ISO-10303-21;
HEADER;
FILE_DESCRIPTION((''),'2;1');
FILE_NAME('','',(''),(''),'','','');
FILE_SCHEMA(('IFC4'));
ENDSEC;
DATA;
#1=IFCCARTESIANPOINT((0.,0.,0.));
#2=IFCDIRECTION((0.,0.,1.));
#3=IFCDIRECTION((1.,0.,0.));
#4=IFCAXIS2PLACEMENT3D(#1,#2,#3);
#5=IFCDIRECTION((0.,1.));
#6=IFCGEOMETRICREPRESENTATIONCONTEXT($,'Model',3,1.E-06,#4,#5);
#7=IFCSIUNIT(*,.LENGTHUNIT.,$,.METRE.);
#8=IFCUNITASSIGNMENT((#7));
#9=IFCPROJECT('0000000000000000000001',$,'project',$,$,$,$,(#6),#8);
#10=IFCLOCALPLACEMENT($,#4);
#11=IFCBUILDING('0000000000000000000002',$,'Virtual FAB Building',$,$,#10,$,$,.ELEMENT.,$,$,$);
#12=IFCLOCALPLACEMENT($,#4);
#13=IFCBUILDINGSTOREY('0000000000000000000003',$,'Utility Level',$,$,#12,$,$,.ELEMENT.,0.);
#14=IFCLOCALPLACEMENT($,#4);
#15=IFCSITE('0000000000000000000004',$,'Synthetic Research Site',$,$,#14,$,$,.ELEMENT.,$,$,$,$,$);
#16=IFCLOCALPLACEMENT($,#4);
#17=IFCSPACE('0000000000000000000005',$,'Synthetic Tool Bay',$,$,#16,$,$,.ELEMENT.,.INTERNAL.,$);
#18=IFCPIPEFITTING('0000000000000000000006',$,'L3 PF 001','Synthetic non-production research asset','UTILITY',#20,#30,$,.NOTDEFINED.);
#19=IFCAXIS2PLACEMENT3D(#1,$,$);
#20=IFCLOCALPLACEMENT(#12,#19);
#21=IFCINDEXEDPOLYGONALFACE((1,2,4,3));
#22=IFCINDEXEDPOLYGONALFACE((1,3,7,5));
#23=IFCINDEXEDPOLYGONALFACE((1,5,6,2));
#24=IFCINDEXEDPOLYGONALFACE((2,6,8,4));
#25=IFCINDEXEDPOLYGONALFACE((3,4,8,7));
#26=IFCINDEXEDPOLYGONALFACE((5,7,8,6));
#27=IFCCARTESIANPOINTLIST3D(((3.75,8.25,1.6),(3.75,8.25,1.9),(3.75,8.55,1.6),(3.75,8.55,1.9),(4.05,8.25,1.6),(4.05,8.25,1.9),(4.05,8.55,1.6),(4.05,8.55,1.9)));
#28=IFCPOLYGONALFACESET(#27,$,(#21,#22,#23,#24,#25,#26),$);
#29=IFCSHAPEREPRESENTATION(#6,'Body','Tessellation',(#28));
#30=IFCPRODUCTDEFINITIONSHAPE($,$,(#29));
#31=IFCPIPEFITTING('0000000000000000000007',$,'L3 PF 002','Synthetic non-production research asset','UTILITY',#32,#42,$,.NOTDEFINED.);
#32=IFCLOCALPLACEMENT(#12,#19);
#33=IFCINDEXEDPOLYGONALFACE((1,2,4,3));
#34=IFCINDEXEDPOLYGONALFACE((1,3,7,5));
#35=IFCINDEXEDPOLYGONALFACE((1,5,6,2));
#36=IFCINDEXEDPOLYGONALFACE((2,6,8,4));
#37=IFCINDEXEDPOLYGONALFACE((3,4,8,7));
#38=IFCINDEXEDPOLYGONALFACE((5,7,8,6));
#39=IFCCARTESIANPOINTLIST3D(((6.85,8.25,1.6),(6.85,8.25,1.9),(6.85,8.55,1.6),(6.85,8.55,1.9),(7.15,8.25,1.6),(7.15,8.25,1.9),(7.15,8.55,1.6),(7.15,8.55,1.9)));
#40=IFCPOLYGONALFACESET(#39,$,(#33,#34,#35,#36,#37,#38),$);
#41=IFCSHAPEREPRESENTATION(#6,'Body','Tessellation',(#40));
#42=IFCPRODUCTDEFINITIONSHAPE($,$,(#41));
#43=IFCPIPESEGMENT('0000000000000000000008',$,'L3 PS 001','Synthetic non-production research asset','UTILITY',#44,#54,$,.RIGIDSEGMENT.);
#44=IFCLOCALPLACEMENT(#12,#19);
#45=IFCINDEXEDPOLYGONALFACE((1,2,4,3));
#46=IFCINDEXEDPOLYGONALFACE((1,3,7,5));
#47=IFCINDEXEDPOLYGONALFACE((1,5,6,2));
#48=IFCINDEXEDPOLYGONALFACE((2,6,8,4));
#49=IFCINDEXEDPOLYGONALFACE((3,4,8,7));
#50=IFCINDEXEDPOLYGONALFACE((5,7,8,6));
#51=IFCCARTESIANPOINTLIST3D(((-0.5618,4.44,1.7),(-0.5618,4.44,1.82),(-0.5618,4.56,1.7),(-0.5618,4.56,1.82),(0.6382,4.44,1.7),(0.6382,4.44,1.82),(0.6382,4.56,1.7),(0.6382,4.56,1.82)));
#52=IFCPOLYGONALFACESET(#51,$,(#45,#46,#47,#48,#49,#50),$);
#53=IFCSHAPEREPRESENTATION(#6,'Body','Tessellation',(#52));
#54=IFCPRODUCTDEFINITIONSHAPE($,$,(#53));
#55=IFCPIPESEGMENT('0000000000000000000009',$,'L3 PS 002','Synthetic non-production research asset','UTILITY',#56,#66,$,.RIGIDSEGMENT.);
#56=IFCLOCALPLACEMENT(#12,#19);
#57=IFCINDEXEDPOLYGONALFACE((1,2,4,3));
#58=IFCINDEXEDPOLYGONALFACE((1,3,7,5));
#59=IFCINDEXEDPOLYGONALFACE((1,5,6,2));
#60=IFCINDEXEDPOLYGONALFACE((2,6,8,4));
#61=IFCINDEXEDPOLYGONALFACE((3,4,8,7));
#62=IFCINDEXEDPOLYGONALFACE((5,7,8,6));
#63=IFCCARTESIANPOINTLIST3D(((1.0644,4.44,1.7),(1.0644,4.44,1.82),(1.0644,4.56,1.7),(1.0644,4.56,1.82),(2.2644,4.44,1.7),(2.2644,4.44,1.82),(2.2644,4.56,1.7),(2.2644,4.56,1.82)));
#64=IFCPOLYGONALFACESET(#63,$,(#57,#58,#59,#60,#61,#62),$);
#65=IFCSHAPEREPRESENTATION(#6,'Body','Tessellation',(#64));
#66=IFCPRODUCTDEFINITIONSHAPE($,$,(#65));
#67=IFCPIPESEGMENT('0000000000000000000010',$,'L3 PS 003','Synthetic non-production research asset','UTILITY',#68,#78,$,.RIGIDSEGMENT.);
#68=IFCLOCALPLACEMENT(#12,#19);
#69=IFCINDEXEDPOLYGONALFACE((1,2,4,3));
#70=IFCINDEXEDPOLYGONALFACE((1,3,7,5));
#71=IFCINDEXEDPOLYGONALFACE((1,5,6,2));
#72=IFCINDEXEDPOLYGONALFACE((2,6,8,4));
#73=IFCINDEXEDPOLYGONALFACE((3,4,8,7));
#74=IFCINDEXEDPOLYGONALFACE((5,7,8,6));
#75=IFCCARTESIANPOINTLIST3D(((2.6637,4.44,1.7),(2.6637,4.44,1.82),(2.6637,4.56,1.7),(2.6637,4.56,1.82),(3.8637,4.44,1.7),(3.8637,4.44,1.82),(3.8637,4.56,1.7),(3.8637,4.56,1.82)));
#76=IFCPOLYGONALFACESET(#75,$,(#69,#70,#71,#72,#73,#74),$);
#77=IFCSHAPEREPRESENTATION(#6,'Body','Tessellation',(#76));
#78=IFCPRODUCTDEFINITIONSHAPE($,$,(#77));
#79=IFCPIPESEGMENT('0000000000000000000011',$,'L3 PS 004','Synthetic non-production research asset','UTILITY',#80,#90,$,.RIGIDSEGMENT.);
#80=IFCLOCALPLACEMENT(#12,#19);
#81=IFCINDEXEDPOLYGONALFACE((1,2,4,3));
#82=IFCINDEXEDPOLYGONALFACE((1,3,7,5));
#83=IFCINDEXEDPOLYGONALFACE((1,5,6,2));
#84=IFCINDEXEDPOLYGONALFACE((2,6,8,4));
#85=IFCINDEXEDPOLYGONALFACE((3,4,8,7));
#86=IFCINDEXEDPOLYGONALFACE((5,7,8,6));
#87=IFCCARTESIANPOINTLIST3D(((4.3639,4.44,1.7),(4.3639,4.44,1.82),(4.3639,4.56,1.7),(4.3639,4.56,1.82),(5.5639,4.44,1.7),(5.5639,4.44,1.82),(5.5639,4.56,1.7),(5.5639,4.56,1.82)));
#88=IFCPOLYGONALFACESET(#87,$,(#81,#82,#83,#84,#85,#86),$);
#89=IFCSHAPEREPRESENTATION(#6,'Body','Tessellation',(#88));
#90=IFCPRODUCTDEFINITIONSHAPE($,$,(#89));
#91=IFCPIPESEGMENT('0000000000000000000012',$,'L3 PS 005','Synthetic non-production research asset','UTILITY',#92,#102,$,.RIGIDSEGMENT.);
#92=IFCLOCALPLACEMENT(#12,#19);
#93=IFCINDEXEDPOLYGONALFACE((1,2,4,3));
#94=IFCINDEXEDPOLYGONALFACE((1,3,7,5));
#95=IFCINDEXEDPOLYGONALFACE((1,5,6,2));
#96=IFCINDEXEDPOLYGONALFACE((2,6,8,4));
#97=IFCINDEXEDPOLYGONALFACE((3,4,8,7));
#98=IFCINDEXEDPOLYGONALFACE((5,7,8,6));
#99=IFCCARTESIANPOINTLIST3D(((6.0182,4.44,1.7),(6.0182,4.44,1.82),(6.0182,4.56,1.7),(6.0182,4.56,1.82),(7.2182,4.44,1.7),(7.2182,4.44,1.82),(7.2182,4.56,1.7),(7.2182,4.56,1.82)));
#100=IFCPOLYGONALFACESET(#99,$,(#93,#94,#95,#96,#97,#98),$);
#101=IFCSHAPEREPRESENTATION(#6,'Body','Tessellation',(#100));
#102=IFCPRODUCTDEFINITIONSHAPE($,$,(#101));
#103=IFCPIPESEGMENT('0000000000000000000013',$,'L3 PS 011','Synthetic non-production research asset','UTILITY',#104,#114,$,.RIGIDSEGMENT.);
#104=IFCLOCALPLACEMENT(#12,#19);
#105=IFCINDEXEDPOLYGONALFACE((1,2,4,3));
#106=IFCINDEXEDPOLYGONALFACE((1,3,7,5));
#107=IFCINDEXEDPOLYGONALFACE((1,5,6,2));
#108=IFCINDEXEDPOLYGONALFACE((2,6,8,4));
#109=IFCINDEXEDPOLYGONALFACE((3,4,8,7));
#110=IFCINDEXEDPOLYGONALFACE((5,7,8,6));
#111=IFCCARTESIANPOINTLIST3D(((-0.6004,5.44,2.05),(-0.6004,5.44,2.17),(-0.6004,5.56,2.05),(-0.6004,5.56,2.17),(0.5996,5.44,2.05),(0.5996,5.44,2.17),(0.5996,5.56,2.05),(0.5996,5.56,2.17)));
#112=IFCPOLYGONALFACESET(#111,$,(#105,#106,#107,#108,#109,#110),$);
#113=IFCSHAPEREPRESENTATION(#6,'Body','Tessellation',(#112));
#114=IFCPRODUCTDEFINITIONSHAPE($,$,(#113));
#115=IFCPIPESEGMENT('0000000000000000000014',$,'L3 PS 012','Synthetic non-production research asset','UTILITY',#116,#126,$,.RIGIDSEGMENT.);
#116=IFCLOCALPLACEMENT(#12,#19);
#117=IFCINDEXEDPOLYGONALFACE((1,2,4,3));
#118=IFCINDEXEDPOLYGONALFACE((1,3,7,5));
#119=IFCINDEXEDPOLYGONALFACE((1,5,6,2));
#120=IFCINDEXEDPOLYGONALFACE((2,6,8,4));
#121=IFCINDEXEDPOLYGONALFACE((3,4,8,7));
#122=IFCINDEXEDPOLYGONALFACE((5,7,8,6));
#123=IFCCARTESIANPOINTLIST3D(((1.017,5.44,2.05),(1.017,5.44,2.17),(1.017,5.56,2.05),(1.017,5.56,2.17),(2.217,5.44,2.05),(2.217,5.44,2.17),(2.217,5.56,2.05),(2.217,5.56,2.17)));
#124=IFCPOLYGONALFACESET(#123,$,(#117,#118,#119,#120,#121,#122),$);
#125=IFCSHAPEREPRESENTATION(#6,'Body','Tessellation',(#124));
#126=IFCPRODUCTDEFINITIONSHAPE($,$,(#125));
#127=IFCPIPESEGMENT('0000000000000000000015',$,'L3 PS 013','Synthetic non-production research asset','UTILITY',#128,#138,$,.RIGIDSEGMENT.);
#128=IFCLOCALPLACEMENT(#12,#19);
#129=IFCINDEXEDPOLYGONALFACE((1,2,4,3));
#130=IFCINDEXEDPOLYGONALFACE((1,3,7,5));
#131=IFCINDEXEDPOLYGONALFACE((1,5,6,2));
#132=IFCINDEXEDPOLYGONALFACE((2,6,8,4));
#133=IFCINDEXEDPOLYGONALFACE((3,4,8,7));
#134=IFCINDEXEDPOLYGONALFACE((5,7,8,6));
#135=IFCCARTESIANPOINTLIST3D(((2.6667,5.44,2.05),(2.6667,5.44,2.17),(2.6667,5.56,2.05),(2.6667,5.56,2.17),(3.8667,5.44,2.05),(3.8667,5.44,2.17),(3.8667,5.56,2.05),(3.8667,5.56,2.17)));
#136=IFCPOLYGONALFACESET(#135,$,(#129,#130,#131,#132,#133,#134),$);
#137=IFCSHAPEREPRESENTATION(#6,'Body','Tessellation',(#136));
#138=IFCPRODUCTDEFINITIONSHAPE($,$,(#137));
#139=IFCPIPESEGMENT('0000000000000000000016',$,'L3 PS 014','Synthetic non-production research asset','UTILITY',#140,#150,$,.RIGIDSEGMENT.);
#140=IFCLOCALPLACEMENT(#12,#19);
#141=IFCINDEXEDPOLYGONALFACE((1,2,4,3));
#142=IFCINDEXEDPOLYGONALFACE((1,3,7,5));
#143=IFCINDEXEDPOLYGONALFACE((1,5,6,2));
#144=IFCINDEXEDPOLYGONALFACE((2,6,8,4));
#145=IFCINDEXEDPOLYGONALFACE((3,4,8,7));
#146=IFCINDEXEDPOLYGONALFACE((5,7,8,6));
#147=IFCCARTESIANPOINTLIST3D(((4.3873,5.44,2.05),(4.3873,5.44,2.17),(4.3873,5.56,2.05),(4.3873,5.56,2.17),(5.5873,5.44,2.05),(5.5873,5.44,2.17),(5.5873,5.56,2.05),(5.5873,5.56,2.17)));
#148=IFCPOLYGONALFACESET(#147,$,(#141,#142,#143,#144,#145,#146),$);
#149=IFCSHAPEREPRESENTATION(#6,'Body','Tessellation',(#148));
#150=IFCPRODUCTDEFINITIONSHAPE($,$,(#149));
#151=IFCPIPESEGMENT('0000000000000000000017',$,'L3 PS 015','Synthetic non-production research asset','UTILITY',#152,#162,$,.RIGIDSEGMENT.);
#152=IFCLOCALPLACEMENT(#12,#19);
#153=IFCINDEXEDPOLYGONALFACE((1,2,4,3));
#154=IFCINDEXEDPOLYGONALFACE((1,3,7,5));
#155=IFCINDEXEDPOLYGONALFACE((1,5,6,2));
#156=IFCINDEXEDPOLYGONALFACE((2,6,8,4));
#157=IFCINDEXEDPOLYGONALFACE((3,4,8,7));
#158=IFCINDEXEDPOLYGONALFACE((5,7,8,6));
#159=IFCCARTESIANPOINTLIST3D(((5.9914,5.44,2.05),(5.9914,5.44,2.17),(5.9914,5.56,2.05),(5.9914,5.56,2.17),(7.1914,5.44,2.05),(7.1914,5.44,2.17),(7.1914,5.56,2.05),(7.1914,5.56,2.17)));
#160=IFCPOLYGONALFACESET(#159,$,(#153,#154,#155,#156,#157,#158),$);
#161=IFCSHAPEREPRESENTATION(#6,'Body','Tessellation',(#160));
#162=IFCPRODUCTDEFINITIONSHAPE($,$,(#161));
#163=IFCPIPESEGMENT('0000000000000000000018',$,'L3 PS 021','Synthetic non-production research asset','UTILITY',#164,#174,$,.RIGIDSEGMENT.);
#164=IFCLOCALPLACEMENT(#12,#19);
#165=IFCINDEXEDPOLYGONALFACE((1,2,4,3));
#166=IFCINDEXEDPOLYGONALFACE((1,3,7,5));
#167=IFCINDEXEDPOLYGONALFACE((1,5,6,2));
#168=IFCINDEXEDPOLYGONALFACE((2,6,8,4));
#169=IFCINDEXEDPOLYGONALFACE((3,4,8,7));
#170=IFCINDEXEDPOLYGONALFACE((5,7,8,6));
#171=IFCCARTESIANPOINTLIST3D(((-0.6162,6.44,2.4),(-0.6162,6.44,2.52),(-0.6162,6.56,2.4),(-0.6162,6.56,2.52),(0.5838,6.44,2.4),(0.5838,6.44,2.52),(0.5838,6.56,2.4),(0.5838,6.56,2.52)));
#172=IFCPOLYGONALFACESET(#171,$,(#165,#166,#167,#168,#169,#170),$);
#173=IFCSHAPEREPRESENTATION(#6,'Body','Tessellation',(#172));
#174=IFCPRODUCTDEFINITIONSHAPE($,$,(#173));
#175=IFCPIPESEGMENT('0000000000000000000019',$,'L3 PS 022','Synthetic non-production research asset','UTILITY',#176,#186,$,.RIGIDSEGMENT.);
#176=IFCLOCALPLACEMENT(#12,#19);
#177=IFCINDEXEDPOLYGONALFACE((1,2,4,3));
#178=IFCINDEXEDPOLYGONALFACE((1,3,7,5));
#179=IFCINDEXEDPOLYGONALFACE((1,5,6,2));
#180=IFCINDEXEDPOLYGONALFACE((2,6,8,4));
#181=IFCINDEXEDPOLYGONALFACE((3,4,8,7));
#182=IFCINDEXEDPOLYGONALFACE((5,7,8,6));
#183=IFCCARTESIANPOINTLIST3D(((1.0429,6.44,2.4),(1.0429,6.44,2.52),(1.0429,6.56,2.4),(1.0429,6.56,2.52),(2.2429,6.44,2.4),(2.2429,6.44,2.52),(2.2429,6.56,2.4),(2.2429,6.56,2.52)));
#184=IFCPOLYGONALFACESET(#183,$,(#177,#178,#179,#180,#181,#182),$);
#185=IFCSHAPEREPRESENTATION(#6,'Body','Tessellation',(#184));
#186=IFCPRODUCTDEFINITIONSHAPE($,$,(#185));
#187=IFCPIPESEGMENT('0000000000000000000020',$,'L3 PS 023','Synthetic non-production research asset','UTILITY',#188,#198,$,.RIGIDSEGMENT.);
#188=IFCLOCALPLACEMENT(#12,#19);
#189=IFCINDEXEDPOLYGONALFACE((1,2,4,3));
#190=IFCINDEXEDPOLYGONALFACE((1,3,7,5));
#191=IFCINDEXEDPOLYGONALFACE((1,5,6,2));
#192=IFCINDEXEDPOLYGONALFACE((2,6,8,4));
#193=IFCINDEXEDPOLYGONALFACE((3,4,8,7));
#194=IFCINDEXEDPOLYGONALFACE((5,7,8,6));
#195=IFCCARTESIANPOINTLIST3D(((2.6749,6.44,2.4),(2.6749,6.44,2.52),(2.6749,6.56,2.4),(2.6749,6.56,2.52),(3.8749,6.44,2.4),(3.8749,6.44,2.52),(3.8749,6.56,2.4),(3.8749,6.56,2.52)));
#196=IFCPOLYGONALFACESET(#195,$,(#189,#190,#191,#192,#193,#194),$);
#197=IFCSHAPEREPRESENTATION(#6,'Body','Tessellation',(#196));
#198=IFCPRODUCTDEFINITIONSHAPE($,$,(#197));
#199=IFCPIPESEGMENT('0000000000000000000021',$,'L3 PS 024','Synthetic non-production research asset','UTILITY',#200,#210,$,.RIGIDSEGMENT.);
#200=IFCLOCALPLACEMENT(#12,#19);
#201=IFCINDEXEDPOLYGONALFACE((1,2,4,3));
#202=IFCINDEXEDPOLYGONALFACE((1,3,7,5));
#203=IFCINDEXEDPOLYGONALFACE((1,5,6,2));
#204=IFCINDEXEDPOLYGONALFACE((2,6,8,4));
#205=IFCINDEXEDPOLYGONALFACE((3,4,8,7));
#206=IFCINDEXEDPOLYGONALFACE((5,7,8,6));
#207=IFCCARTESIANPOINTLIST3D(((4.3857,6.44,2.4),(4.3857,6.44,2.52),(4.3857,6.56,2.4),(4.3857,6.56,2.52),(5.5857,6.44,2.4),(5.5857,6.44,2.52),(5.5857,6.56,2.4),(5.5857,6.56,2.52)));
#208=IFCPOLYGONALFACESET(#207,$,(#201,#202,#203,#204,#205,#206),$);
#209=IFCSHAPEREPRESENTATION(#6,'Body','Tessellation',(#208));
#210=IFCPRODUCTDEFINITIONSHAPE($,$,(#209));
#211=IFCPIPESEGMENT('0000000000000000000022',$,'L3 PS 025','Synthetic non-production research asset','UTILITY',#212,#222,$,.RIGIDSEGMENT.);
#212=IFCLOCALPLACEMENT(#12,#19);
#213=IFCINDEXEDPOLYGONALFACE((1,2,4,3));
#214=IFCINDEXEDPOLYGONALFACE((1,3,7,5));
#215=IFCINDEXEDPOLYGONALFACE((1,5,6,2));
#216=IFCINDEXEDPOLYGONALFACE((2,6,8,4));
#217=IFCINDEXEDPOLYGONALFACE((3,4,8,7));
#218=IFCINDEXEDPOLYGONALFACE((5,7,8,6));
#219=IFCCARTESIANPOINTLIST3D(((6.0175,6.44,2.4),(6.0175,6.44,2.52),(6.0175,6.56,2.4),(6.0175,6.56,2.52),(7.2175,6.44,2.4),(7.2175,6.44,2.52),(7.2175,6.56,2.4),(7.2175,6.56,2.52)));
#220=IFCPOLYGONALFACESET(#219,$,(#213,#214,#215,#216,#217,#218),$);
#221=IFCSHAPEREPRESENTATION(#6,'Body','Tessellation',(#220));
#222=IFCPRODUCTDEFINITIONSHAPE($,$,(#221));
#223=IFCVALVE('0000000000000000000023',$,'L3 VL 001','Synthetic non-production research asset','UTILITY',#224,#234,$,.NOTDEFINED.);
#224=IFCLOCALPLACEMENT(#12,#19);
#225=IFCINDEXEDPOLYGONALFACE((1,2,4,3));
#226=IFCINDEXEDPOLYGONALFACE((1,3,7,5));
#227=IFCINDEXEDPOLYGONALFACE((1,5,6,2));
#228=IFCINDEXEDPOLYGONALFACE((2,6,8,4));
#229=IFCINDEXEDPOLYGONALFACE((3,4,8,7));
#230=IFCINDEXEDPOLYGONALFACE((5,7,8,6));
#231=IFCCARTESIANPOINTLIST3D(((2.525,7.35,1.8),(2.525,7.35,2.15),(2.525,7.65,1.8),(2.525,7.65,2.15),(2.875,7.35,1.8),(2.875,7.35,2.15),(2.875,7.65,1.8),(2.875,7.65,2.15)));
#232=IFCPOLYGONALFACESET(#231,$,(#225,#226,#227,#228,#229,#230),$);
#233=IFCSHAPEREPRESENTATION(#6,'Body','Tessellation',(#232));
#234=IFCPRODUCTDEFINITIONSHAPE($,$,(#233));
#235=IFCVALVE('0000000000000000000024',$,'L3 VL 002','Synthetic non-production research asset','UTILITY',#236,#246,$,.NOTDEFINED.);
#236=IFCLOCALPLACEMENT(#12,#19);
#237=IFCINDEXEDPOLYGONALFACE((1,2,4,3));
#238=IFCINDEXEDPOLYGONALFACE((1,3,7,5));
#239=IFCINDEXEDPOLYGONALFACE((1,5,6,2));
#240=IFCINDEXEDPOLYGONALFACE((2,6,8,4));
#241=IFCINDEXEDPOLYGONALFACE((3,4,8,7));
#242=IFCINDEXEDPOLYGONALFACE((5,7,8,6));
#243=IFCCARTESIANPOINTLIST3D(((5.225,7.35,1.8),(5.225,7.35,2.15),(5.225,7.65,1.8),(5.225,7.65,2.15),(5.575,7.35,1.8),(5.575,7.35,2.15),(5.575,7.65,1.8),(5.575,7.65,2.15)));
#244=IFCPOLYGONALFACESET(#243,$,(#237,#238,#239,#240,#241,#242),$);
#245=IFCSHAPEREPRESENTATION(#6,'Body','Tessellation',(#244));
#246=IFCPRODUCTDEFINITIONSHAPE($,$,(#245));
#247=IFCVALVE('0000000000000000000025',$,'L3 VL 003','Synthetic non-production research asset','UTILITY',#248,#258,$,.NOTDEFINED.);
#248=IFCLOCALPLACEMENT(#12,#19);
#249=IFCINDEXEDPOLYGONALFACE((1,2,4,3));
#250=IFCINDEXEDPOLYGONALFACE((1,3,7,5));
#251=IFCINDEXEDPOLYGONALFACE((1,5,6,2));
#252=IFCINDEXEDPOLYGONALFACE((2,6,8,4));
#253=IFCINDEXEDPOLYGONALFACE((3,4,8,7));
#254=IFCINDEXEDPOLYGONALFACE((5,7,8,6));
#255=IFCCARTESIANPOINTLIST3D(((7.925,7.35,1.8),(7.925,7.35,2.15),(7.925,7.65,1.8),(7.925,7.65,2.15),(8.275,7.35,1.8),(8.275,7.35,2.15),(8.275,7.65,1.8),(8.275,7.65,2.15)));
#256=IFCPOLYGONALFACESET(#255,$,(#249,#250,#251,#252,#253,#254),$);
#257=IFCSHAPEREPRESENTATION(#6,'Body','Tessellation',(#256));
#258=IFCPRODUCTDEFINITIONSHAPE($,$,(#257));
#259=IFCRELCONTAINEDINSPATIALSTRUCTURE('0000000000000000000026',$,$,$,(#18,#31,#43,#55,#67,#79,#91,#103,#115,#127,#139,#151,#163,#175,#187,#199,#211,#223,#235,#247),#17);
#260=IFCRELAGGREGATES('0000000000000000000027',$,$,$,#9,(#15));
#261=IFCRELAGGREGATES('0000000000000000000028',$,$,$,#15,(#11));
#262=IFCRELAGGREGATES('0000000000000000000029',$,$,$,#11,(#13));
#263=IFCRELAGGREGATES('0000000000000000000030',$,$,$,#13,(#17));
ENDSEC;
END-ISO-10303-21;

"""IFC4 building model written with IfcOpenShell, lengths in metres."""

from ifc_helpers import new_model, si_unit, direction, frame, origin_with_axes, origin_2d_with_axis, place, context, project, spatial, rectangle, extrude, element, save


model = new_model("IFC4")

# Units and contexts
model_context = context("Model", 3, precision=1e-06, world=origin_with_axes(), true_north=direction((0.0, 1.0)))
ifc_project = project(units=[si_unit("LENGTHUNIT", "METRE")], contexts=[model_context])

# Site, building, storey, space
site_placement = place(None, origin_with_axes())
site = spatial("IfcSite", under=ifc_project, at=site_placement, Name="Synthetic Research Site", CompositionType="ELEMENT")
building_placement = place(None, origin_with_axes())
building = spatial("IfcBuilding", under=site, at=building_placement, Name="Virtual FAB Building", CompositionType="ELEMENT")
storey_placement = place(None, origin_with_axes())
storey = spatial("IfcBuildingStorey", under=building, at=storey_placement, Name="Utility Level", CompositionType="ELEMENT", Elevation=0.0)
space_placement = place(None, origin_with_axes())
space = spatial("IfcSpace", under=storey, at=space_placement, Name="Synthetic Tool Bay", CompositionType="ELEMENT", PredefinedType="INTERNAL")

# Pipe fittings
for number, where, z_axis, x_axis, name in (
    (1, (3.9, 8.4, 1.6), (0.0, 0.0, 1.0), (1.0, 0.0, 0.0), "L3 PF 001"),
    (2, (7.0, 8.4, 1.6), (0.0, 0.0, 1.0), (1.0, 0.0, 0.0), "L3 PF 002"),
):
    element("IfcPipeFitting", number, at=place(None, frame(where, z_axis=z_axis, x_axis=x_axis)), inside=space, Name=name, Description="Synthetic non-production research asset", ObjectType="UTILITY", PredefinedType="NOTDEFINED", context=model_context, shape_type="SweptSolid", body=[
        extrude(rectangle(XDim=0.3, YDim=0.3, at=origin_2d_with_axis()), origin_with_axes(), (0.0, 0.0, 1.0), 0.3),
    ])

# Pipe segments
for number, where, z_axis, x_axis, name in (
    (3, (0.0382, 4.5, 1.7), (0.0, 0.0, 1.0), (1.0, 0.0, 0.0), "L3 PS 001"),
    (4, (1.6644, 4.5, 1.7), (0.0, 0.0, 1.0), (1.0, 0.0, 0.0), "L3 PS 002"),
    (5, (3.2637, 4.5, 1.7), (0.0, 0.0, 1.0), (1.0, 0.0, 0.0), "L3 PS 003"),
    (6, (4.9639, 4.5, 1.7), (0.0, 0.0, 1.0), (1.0, 0.0, 0.0), "L3 PS 004"),
    (7, (6.6182, 4.5, 1.7), (0.0, 0.0, 1.0), (1.0, 0.0, 0.0), "L3 PS 005"),
    (8, (-0.0004, 5.5, 2.05), (0.0, 0.0, 1.0), (1.0, 0.0, 0.0), "L3 PS 011"),
    (9, (1.617, 5.5, 2.05), (0.0, 0.0, 1.0), (1.0, 0.0, 0.0), "L3 PS 012"),
    (10, (3.2667, 5.5, 2.05), (0.0, 0.0, 1.0), (1.0, 0.0, 0.0), "L3 PS 013"),
    (11, (4.9873, 5.5, 2.05), (0.0, 0.0, 1.0), (1.0, 0.0, 0.0), "L3 PS 014"),
    (12, (6.5914, 5.5, 2.05), (0.0, 0.0, 1.0), (1.0, 0.0, 0.0), "L3 PS 015"),
    (13, (-0.0162, 6.5, 2.4), (0.0, 0.0, 1.0), (1.0, 0.0, 0.0), "L3 PS 021"),
    (14, (1.6429, 6.5, 2.4), (0.0, 0.0, 1.0), (1.0, 0.0, 0.0), "L3 PS 022"),
    (15, (3.2749, 6.5, 2.4), (0.0, 0.0, 1.0), (1.0, 0.0, 0.0), "L3 PS 023"),
    (16, (4.9857, 6.5, 2.4), (0.0, 0.0, 1.0), (1.0, 0.0, 0.0), "L3 PS 024"),
    (17, (6.6175, 6.5, 2.4), (0.0, 0.0, 1.0), (1.0, 0.0, 0.0), "L3 PS 025"),
):
    element("IfcPipeSegment", number, at=place(None, frame(where, z_axis=z_axis, x_axis=x_axis)), inside=space, Name=name, Description="Synthetic non-production research asset", ObjectType="UTILITY", PredefinedType="RIGIDSEGMENT", context=model_context, shape_type="SweptSolid", body=[
        extrude(rectangle(XDim=1.2, YDim=0.12, at=origin_2d_with_axis()), origin_with_axes(), (0.0, 0.0, 1.0), 0.12),
    ])

# Valves
for number, where, z_axis, x_axis, name in (
    (18, (2.7, 7.5, 1.8), (0.0, 0.0, 1.0), (1.0, 0.0, 0.0), "L3 VL 001"),
    (19, (5.4, 7.5, 1.8), (0.0, 0.0, 1.0), (1.0, 0.0, 0.0), "L3 VL 002"),
    (20, (8.1, 7.5, 1.8), (0.0, 0.0, 1.0), (1.0, 0.0, 0.0), "L3 VL 003"),
):
    element("IfcValve", number, at=place(None, frame(where, z_axis=z_axis, x_axis=x_axis)), inside=space, Name=name, Description="Synthetic non-production research asset", ObjectType="UTILITY", PredefinedType="NOTDEFINED", context=model_context, shape_type="SweptSolid", body=[
        extrude(rectangle(XDim=0.35, YDim=0.3, at=origin_2d_with_axis()), origin_with_axes(), (0.0, 0.0, 1.0), 0.35),
    ])

save(model, "model.ifc")
